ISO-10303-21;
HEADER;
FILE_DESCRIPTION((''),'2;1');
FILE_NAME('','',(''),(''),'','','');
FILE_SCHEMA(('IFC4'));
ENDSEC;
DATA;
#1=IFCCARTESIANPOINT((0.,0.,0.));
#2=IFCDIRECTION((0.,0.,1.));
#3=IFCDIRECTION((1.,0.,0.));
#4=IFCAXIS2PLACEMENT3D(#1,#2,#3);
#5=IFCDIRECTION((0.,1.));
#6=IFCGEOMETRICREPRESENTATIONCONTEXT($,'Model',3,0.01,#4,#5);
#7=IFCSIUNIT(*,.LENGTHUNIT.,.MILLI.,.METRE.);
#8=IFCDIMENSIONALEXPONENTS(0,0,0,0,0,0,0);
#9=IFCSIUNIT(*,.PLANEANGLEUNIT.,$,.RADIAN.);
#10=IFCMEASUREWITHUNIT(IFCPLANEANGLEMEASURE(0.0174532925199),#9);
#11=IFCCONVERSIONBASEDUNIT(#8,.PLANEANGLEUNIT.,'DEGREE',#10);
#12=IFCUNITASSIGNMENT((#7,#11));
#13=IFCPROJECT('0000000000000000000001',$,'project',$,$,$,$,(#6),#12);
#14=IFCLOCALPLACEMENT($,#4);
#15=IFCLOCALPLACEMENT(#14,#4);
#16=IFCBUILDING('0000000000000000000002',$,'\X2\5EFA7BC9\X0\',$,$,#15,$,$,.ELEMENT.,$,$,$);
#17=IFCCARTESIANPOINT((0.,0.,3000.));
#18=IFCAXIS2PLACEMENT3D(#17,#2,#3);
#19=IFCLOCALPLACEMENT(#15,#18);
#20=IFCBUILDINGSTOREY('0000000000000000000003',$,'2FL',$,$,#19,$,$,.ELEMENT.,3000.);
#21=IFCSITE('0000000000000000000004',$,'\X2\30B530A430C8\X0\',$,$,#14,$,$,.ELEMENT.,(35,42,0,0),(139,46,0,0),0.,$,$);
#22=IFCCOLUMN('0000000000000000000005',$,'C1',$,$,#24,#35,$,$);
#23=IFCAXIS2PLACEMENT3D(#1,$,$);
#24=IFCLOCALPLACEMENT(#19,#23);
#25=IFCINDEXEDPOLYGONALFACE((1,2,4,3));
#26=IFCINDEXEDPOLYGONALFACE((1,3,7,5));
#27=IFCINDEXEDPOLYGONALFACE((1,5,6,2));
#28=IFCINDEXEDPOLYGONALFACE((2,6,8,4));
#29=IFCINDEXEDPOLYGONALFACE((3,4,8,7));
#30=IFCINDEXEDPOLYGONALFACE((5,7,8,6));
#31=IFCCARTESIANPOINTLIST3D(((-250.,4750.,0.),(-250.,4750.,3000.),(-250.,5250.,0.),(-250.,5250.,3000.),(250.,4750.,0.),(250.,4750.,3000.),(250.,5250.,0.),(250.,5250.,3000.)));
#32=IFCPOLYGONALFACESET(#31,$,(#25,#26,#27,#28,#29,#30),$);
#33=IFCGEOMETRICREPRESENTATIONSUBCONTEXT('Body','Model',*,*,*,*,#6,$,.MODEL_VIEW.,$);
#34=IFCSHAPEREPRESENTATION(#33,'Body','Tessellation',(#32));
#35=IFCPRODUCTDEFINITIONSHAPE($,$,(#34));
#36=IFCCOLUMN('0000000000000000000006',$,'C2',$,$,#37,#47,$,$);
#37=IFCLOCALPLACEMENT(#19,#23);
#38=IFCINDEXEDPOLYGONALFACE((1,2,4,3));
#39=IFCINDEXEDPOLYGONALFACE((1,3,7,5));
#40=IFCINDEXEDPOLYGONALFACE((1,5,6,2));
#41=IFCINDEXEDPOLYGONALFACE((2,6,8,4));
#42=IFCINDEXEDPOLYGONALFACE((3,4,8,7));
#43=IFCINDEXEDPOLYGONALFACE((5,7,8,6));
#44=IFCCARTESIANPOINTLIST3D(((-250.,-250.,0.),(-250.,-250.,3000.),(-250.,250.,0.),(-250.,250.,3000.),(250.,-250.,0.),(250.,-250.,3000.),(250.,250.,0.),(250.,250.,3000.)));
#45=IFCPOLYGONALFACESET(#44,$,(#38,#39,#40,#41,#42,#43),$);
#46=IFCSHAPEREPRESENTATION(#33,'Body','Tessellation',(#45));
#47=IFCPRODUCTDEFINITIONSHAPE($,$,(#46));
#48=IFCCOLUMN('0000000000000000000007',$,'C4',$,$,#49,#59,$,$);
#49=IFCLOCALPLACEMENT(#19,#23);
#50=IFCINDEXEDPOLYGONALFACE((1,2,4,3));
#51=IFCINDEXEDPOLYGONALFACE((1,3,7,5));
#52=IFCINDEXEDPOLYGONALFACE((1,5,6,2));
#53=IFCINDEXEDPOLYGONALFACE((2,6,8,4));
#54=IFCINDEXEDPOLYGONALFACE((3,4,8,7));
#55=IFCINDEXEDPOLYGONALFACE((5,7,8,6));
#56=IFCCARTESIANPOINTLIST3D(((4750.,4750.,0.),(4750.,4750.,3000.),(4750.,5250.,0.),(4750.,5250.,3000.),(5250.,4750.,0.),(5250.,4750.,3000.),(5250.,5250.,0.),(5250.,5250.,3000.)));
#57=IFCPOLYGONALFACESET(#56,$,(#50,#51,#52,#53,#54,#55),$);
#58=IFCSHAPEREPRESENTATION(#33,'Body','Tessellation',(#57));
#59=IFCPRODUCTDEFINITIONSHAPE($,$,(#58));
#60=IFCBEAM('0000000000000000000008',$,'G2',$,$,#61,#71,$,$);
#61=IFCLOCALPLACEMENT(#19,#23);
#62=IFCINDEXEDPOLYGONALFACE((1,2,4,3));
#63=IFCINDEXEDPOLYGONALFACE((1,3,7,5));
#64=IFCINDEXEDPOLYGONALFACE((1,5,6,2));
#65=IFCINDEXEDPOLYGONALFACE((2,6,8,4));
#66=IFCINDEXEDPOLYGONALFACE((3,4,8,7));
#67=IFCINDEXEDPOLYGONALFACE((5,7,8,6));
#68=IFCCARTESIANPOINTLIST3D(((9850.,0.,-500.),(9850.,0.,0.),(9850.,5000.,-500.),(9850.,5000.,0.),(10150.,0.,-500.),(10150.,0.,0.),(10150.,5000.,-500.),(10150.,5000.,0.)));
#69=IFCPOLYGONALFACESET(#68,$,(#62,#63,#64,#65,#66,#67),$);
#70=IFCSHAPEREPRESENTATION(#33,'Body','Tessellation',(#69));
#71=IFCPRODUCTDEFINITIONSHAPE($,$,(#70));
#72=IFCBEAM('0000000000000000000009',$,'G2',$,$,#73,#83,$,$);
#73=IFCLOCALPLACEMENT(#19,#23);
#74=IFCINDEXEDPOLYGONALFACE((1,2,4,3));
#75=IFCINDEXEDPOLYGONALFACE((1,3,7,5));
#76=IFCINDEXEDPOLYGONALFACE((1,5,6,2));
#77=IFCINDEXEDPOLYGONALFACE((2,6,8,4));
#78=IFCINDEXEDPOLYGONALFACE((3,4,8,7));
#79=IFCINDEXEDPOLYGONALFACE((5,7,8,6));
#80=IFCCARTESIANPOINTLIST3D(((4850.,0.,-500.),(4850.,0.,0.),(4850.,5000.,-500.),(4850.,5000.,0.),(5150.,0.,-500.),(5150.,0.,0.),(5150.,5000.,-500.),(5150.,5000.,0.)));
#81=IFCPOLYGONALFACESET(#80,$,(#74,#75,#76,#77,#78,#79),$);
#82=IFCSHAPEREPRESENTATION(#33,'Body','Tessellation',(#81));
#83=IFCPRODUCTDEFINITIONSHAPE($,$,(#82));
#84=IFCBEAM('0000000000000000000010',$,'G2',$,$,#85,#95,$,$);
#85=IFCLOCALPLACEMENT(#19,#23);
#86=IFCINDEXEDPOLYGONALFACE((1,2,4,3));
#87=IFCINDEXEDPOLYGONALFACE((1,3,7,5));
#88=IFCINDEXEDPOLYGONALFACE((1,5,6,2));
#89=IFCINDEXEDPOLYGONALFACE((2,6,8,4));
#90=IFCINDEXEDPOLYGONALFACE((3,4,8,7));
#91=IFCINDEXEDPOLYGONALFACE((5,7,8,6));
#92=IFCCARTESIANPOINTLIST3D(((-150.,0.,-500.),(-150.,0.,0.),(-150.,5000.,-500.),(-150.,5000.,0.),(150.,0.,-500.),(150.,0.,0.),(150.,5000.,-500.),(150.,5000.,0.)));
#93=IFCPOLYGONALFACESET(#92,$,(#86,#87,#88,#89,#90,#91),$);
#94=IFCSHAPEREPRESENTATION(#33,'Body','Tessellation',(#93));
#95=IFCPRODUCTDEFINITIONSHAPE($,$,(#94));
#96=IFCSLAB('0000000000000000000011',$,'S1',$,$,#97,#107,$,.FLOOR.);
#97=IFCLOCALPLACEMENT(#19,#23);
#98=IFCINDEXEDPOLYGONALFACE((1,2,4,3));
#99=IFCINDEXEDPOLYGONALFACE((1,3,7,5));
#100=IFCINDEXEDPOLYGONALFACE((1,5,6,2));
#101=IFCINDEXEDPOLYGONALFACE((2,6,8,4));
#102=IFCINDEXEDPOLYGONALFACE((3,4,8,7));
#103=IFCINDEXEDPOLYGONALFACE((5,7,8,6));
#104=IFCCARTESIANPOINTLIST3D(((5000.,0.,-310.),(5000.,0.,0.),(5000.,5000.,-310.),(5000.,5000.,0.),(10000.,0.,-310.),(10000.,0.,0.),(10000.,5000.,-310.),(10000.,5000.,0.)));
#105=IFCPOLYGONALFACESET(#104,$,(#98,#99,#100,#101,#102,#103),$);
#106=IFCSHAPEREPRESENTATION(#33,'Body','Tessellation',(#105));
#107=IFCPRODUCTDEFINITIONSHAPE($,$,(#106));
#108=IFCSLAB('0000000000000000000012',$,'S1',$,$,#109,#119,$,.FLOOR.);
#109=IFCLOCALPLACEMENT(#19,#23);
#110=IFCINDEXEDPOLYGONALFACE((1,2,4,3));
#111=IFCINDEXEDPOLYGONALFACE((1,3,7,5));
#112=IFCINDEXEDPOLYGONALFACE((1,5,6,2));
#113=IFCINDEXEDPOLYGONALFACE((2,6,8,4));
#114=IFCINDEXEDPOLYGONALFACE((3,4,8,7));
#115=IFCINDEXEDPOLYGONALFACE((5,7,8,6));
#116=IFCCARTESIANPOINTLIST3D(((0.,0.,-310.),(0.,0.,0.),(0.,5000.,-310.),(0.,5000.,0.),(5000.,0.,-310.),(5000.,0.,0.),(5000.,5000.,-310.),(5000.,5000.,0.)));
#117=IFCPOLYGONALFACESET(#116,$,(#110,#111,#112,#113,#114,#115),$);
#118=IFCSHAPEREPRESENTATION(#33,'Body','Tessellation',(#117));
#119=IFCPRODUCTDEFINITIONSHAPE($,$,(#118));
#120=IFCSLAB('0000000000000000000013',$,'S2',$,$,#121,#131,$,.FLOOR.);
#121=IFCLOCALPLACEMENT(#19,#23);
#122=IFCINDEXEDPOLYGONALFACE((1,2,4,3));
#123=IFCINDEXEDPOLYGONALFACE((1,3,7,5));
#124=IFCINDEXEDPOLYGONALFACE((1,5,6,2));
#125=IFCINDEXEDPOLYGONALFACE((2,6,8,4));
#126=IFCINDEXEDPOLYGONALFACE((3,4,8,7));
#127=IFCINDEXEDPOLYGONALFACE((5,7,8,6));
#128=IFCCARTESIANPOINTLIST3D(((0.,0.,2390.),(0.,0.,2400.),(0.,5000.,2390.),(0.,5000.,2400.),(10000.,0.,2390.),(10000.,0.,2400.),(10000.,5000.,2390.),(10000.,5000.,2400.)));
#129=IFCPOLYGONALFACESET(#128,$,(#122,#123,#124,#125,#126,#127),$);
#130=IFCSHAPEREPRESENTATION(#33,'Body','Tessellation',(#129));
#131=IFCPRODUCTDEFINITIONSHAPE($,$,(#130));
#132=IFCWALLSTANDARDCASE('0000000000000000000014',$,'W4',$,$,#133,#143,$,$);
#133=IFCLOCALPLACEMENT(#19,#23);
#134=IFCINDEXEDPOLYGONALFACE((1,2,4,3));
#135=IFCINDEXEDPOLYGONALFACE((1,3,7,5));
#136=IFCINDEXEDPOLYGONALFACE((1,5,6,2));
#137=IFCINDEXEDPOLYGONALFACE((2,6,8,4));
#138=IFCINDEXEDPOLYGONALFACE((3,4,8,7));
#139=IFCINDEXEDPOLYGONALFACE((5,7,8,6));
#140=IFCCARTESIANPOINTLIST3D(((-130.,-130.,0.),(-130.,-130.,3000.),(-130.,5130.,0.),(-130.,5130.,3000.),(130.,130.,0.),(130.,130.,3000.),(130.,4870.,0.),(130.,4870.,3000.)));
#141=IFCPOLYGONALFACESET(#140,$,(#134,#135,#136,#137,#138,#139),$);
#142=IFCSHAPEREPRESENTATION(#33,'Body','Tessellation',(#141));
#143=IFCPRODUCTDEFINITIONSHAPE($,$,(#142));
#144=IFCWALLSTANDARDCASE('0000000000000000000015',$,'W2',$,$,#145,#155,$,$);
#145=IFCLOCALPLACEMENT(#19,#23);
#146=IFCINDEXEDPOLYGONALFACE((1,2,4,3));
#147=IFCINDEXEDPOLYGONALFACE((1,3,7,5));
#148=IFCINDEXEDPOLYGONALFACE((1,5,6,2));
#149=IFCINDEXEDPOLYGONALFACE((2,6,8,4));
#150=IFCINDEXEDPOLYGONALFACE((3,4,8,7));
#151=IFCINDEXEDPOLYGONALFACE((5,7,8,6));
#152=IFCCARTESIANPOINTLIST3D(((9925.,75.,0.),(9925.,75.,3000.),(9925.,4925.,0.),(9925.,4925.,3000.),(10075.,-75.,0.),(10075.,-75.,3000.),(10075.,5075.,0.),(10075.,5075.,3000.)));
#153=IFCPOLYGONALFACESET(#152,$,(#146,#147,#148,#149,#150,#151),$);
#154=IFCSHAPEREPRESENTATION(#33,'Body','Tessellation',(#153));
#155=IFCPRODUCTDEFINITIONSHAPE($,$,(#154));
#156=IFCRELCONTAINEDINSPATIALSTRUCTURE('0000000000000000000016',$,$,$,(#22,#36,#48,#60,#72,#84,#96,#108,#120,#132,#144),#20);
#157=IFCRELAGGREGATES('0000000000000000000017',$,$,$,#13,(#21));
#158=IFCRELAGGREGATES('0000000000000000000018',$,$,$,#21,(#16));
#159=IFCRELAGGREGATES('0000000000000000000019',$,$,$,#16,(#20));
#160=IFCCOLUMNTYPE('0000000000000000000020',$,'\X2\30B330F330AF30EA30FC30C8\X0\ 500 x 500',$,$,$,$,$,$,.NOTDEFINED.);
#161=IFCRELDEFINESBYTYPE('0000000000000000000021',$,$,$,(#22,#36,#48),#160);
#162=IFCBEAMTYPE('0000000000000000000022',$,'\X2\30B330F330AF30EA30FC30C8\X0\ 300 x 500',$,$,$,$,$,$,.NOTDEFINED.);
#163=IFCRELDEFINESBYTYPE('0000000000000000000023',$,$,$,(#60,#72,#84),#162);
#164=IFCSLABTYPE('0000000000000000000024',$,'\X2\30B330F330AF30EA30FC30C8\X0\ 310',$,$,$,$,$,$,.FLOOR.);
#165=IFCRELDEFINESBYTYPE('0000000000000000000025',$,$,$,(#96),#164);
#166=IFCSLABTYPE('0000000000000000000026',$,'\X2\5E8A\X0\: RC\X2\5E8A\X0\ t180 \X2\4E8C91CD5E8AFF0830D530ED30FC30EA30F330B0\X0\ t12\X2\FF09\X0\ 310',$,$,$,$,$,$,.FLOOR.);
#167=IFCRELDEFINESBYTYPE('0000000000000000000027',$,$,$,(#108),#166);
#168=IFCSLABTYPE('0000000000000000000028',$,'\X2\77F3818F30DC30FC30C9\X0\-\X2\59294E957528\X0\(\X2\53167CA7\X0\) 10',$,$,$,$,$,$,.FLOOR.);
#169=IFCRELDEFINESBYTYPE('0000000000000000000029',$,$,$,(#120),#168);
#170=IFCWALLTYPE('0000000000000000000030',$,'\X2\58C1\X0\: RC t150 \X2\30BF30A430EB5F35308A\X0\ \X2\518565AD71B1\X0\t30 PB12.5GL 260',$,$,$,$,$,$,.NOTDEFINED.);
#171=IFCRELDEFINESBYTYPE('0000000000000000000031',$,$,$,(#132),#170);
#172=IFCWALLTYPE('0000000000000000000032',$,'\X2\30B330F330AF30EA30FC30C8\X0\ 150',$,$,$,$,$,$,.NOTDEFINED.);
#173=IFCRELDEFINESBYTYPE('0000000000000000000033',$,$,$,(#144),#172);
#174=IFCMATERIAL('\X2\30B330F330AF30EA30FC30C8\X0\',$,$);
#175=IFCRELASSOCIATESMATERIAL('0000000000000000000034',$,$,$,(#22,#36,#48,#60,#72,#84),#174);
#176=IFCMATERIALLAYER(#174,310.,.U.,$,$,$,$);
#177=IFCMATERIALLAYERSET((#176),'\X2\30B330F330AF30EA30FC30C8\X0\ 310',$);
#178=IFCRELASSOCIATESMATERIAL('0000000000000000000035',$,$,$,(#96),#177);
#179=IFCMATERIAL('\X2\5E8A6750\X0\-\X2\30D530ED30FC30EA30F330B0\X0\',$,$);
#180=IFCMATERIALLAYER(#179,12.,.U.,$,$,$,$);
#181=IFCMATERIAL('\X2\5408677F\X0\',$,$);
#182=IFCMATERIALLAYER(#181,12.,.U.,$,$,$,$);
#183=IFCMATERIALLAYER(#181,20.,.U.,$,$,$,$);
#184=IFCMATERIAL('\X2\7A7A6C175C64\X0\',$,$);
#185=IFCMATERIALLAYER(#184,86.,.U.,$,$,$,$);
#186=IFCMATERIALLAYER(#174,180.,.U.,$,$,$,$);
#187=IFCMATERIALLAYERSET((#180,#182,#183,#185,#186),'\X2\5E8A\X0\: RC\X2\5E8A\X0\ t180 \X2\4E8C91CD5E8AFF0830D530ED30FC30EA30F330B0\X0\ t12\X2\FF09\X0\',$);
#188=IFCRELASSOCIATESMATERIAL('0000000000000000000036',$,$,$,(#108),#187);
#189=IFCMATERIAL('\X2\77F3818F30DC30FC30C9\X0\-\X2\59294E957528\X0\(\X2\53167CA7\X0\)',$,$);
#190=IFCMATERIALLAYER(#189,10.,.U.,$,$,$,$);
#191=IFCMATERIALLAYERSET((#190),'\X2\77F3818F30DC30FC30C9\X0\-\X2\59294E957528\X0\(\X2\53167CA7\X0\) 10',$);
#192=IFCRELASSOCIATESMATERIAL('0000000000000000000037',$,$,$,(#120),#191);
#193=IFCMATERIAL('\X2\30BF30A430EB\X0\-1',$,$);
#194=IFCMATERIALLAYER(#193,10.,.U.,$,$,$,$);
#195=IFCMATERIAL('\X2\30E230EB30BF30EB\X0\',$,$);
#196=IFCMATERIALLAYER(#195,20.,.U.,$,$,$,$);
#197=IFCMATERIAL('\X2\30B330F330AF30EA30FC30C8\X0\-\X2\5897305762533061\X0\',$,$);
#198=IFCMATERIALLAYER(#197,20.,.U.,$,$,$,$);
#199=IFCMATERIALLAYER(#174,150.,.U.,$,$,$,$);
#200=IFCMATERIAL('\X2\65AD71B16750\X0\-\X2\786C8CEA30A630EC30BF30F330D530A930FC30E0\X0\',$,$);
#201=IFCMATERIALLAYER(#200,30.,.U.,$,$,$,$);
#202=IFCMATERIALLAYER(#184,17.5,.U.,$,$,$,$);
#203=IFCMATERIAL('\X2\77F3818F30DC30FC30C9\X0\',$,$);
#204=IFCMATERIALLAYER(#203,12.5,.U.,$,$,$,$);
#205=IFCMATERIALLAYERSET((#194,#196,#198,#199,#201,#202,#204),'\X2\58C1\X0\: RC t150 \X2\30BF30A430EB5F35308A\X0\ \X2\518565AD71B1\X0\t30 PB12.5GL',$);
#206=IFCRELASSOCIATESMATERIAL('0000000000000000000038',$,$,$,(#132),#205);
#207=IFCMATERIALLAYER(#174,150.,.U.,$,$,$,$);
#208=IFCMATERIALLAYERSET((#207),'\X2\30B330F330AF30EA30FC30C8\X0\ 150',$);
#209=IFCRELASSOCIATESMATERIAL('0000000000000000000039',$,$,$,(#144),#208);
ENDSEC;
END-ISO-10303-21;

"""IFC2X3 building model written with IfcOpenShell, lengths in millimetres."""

from ifc_helpers import new_model, entity, si_unit, converted_unit, direction, frame, frame_2d, origin_with_axes, origin_2d_with_axis, place, context, subcontext, project, spatial, polyline, rectangle, outline, extrude, material, layer, layer_set, layer_usage, type_object, element, save


model = new_model("IFC2X3")

# Units and contexts
model_context = context("Model", 3, precision=0.01, world=origin_with_axes(), true_north=direction((0.0, 1.0)))
body_context = subcontext(model_context, "Body", "Model", "MODEL_VIEW")
ifc_project = project(units=[si_unit("LENGTHUNIT", "METRE", prefix="MILLI"), converted_unit("PLANEANGLEUNIT", "DEGREE", entity("IfcPlaneAngleMeasure", 0.0174532925199), si_unit("PLANEANGLEUNIT", "RADIAN"), dimensions=[0, 0, 0, 0, 0, 0, 0])], contexts=[model_context])

# Site, building, storey
site_placement = place(None, origin_with_axes())
site = spatial("IfcSite", under=ifc_project, at=site_placement, Name="サイト", CompositionType="ELEMENT", RefLatitude=(35, 42, 0, 0), RefLongitude=(139, 46, 0, 0), RefElevation=0.0)
building_placement = place(site_placement, origin_with_axes())
building = spatial("IfcBuilding", under=site, at=building_placement, Name="建築", CompositionType="ELEMENT")
storey_placement = place(building_placement, frame((0.0, 0.0, 3000.0), z_axis=(0.0, 0.0, 1.0), x_axis=(1.0, 0.0, 0.0)))
storey = spatial("IfcBuildingStorey", under=building, at=storey_placement, Name="2FL", CompositionType="ELEMENT", Elevation=3000.0)

# Columns
ifc_material_1 = material(Name="コンクリート")
column_type_1 = type_object("IfcColumnType", Name="コンクリート 500 x 500", PredefinedType="NOTDEFINED")
for number, where, z_axis, x_axis, name in (
    (1, (0.0, 5000.0, 0.0), (0.0, 0.0, 1.0), (1.0, 0.0, 0.0), "C1"),
    (2, (0.0, 0.0, 0.0), (0.0, 0.0, 1.0), (1.0, 0.0, 0.0), "C2"),
    (3, (5000.0, 5000.0, 0.0), (0.0, 0.0, 1.0), (1.0, 0.0, 0.0), "C4"),
):
    element("IfcColumn", number, at=place(storey_placement, frame(where, z_axis=z_axis, x_axis=x_axis)), inside=storey, type_object=column_type_1, material=ifc_material_1, Name=name, context=body_context, shape_type="SweptSolid", body=[
        extrude(rectangle(XDim=500.0, YDim=500.0, at=origin_2d_with_axis()), origin_with_axes(), (0.0, 0.0, 1.0), 3000.0),
    ])

# Beams
beam_type_1 = type_object("IfcBeamType", Name="コンクリート 300 x 500", PredefinedType="NOTDEFINED")
for number, where, z_axis, x_axis, name in (
    (4, (10000.0, 5000.0, 0.0), (0.0, 0.0, 1.0), (-1.0, 0.0, 0.0), "G2"),
    (5, (5000.0, 5000.0, 0.0), (0.0, 0.0, 1.0), (-1.0, 0.0, 0.0), "G2"),
    (6, (0.0, 5000.0, 0.0), (0.0, 0.0, 1.0), (-1.0, 0.0, 0.0), "G2"),
):
    element("IfcBeam", number, at=place(storey_placement, frame(where, z_axis=z_axis, x_axis=x_axis)), inside=storey, type_object=beam_type_1, material=ifc_material_1, Name=name, context=body_context, shape_type="SweptSolid", body=[
        extrude(rectangle(XDim=500.0, YDim=300.0, at=frame_2d((-250.0, 0.0), x_axis=(1.0, 0.0))), frame((0.0, 0.0, 0.0), z_axis=(0.0, 1.0, 0.0), x_axis=(0.0, 0.0, 1.0)), (0.0, 0.0, 1.0), 5000.0),
    ])

# Slabs
ifc_layer_1 = layer(ifc_material_1, 310.0, ventilated="UNKNOWN")
ifc_layer_set_1 = layer_set([ifc_layer_1], Name="コンクリート 310")
ifc_layer_usage_1 = layer_usage(ifc_layer_set_1, "AXIS3", "NEGATIVE", 310.0)
slab_type_1 = type_object("IfcSlabType", Name="コンクリート 310", PredefinedType="FLOOR")
slab_1_placement = place(storey_placement, frame((5000.0, 0.0, 0.0), z_axis=(0.0, 0.0, 1.0), x_axis=(1.0, 0.0, 0.0)))
element("IfcSlab", 7, at=slab_1_placement, inside=storey, type_object=slab_type_1, material=ifc_layer_usage_1, Name="S1", PredefinedType="FLOOR", context=body_context, shape_type="SweptSolid", body=[
    extrude(outline(polyline([(0.0, 0.0), (5000.0, 0.0), (5000.0, 5000.0), (0.0, 5000.0), (0.0, 0.0)])), frame((0.0, 0.0, -310.0), z_axis=(0.0, 0.0, 1.0), x_axis=(1.0, 0.0, 0.0)), (0.0, 0.0, 1.0), 310.0),
])
ifc_material_2 = material(Name="床材-フローリング")
ifc_layer_2 = layer(ifc_material_2, 12.0, ventilated="UNKNOWN")
ifc_material_3 = material(Name="合板")
ifc_layer_3 = layer(ifc_material_3, 12.0, ventilated="UNKNOWN")
ifc_layer_4 = layer(ifc_material_3, 20.0, ventilated="UNKNOWN")
ifc_material_4 = material(Name="空気層")
ifc_layer_5 = layer(ifc_material_4, 86.0, ventilated="UNKNOWN")
ifc_layer_6 = layer(ifc_material_1, 180.0, ventilated="UNKNOWN")
ifc_layer_set_2 = layer_set([ifc_layer_2, ifc_layer_3, ifc_layer_4, ifc_layer_5, ifc_layer_6], Name="床: RC床 t180 二重床（フローリング t12）")
ifc_layer_usage_2 = layer_usage(ifc_layer_set_2, "AXIS3", "NEGATIVE", 310.0)
slab_type_2 = type_object("IfcSlabType", Name="床: RC床 t180 二重床（フローリング t12） 310", PredefinedType="FLOOR")
slab_2_placement = place(storey_placement, origin_with_axes())
element("IfcSlab", 8, at=slab_2_placement, inside=storey, type_object=slab_type_2, material=ifc_layer_usage_2, Name="S1", PredefinedType="FLOOR", context=body_context, shape_type="SweptSolid", body=[
    extrude(outline(polyline([(0.0, 0.0), (5000.0, 0.0), (5000.0, 5000.0), (0.0, 5000.0), (0.0, 0.0)])), frame((0.0, 0.0, -310.0), z_axis=(0.0, 0.0, 1.0), x_axis=(1.0, 0.0, 0.0)), (0.0, 0.0, 1.0), 310.0),
])
ifc_material_5 = material(Name="石膏ボード-天井用(化粧)")
ifc_layer_7 = layer(ifc_material_5, 10.0, ventilated="UNKNOWN")
ifc_layer_set_3 = layer_set([ifc_layer_7], Name="石膏ボード-天井用(化粧) 10")
ifc_layer_usage_3 = layer_usage(ifc_layer_set_3, "AXIS3", "NEGATIVE", 10.0)
slab_type_3 = type_object("IfcSlabType", Name="石膏ボード-天井用(化粧) 10", PredefinedType="FLOOR")
slab_3_placement = place(storey_placement, frame((0.0, 0.0, 2400.0), z_axis=(0.0, 0.0, 1.0), x_axis=(1.0, 0.0, 0.0)))
element("IfcSlab", 9, at=slab_3_placement, inside=storey, type_object=slab_type_3, material=ifc_layer_usage_3, Name="S2", PredefinedType="FLOOR", context=body_context, shape_type="SweptSolid", body=[
    extrude(outline(polyline([(0.0, 0.0), (10000.0, 0.0), (10000.0, 5000.0), (0.0, 5000.0), (0.0, 0.0)])), frame((0.0, 0.0, -10.0), z_axis=(0.0, 0.0, 1.0), x_axis=(1.0, 0.0, 0.0)), (0.0, 0.0, 1.0), 10.0),
])

# Shared definitions
ifc_material_6 = material(Name="タイル-1")
ifc_layer_8 = layer(ifc_material_6, 10.0, ventilated="UNKNOWN")
ifc_material_7 = material(Name="モルタル")
ifc_layer_9 = layer(ifc_material_7, 20.0, ventilated="UNKNOWN")
ifc_material_8 = material(Name="コンクリート-増し打ち")
ifc_layer_10 = layer(ifc_material_8, 20.0, ventilated="UNKNOWN")
ifc_layer_11 = layer(ifc_material_1, 150.0, ventilated="UNKNOWN")
ifc_material_9 = material(Name="断熱材-硬質ウレタンフォーム")
ifc_layer_12 = layer(ifc_material_9, 30.0, ventilated="UNKNOWN")
ifc_layer_13 = layer(ifc_material_4, 17.5, ventilated="UNKNOWN")
ifc_material_10 = material(Name="石膏ボード")
ifc_layer_14 = layer(ifc_material_10, 12.5, ventilated="UNKNOWN")
ifc_layer_set_4 = layer_set([ifc_layer_8, ifc_layer_9, ifc_layer_10, ifc_layer_11, ifc_layer_12, ifc_layer_13, ifc_layer_14], Name="壁: RC t150 タイル張り 内断熱t30 PB12.5GL")
wall_type_1 = type_object("IfcWallType", Name="壁: RC t150 タイル張り 内断熱t30 PB12.5GL 260", PredefinedType="NOTDEFINED")

# Wall
ifc_layer_usage_4 = layer_usage(ifc_layer_set_4, "AXIS2", "POSITIVE", -130.0)
wall_1_placement = place(storey_placement, frame((0.0, 5000.0, 0.0), z_axis=(0.0, 0.0, 1.0), x_axis=(0.0, -1.0, 0.0)))
element("IfcWallStandardCase", 10, at=wall_1_placement, inside=storey, type_object=wall_type_1, material=ifc_layer_usage_4, Name="W4", context=body_context, shape_type="SweptSolid", body=[
    extrude(outline(polyline([(-130.0, -130.0), (5130.0, -130.0), (4870.0, 130.0), (130.0, 130.0), (-130.0, -130.0)])), origin_with_axes(), (0.0, 0.0, 1.0), 3000.0),
])

# Wall
ifc_layer_15 = layer(ifc_material_1, 150.0, ventilated="UNKNOWN")
ifc_layer_set_5 = layer_set([ifc_layer_15], Name="コンクリート 150")
ifc_layer_usage_5 = layer_usage(ifc_layer_set_5, "AXIS2", "POSITIVE", -75.0)
wall_type_2 = type_object("IfcWallType", Name="コンクリート 150", PredefinedType="NOTDEFINED")
wall_2_placement = place(storey_placement, frame((10000.0, 0.0, 0.0), z_axis=(0.0, 0.0, 1.0), x_axis=(0.0, 1.0, 0.0)))
element("IfcWallStandardCase", 11, at=wall_2_placement, inside=storey, type_object=wall_type_2, material=ifc_layer_usage_5, Name="W2", context=body_context, shape_type="SweptSolid", body=[
    extrude(outline(polyline([(-75.0, -75.0), (5075.0, -75.0), (4925.0, 75.0), (75.0, 75.0), (-75.0, -75.0)])), origin_with_axes(), (0.0, 0.0, 1.0), 3000.0),
])

save(model, "model.ifc")
